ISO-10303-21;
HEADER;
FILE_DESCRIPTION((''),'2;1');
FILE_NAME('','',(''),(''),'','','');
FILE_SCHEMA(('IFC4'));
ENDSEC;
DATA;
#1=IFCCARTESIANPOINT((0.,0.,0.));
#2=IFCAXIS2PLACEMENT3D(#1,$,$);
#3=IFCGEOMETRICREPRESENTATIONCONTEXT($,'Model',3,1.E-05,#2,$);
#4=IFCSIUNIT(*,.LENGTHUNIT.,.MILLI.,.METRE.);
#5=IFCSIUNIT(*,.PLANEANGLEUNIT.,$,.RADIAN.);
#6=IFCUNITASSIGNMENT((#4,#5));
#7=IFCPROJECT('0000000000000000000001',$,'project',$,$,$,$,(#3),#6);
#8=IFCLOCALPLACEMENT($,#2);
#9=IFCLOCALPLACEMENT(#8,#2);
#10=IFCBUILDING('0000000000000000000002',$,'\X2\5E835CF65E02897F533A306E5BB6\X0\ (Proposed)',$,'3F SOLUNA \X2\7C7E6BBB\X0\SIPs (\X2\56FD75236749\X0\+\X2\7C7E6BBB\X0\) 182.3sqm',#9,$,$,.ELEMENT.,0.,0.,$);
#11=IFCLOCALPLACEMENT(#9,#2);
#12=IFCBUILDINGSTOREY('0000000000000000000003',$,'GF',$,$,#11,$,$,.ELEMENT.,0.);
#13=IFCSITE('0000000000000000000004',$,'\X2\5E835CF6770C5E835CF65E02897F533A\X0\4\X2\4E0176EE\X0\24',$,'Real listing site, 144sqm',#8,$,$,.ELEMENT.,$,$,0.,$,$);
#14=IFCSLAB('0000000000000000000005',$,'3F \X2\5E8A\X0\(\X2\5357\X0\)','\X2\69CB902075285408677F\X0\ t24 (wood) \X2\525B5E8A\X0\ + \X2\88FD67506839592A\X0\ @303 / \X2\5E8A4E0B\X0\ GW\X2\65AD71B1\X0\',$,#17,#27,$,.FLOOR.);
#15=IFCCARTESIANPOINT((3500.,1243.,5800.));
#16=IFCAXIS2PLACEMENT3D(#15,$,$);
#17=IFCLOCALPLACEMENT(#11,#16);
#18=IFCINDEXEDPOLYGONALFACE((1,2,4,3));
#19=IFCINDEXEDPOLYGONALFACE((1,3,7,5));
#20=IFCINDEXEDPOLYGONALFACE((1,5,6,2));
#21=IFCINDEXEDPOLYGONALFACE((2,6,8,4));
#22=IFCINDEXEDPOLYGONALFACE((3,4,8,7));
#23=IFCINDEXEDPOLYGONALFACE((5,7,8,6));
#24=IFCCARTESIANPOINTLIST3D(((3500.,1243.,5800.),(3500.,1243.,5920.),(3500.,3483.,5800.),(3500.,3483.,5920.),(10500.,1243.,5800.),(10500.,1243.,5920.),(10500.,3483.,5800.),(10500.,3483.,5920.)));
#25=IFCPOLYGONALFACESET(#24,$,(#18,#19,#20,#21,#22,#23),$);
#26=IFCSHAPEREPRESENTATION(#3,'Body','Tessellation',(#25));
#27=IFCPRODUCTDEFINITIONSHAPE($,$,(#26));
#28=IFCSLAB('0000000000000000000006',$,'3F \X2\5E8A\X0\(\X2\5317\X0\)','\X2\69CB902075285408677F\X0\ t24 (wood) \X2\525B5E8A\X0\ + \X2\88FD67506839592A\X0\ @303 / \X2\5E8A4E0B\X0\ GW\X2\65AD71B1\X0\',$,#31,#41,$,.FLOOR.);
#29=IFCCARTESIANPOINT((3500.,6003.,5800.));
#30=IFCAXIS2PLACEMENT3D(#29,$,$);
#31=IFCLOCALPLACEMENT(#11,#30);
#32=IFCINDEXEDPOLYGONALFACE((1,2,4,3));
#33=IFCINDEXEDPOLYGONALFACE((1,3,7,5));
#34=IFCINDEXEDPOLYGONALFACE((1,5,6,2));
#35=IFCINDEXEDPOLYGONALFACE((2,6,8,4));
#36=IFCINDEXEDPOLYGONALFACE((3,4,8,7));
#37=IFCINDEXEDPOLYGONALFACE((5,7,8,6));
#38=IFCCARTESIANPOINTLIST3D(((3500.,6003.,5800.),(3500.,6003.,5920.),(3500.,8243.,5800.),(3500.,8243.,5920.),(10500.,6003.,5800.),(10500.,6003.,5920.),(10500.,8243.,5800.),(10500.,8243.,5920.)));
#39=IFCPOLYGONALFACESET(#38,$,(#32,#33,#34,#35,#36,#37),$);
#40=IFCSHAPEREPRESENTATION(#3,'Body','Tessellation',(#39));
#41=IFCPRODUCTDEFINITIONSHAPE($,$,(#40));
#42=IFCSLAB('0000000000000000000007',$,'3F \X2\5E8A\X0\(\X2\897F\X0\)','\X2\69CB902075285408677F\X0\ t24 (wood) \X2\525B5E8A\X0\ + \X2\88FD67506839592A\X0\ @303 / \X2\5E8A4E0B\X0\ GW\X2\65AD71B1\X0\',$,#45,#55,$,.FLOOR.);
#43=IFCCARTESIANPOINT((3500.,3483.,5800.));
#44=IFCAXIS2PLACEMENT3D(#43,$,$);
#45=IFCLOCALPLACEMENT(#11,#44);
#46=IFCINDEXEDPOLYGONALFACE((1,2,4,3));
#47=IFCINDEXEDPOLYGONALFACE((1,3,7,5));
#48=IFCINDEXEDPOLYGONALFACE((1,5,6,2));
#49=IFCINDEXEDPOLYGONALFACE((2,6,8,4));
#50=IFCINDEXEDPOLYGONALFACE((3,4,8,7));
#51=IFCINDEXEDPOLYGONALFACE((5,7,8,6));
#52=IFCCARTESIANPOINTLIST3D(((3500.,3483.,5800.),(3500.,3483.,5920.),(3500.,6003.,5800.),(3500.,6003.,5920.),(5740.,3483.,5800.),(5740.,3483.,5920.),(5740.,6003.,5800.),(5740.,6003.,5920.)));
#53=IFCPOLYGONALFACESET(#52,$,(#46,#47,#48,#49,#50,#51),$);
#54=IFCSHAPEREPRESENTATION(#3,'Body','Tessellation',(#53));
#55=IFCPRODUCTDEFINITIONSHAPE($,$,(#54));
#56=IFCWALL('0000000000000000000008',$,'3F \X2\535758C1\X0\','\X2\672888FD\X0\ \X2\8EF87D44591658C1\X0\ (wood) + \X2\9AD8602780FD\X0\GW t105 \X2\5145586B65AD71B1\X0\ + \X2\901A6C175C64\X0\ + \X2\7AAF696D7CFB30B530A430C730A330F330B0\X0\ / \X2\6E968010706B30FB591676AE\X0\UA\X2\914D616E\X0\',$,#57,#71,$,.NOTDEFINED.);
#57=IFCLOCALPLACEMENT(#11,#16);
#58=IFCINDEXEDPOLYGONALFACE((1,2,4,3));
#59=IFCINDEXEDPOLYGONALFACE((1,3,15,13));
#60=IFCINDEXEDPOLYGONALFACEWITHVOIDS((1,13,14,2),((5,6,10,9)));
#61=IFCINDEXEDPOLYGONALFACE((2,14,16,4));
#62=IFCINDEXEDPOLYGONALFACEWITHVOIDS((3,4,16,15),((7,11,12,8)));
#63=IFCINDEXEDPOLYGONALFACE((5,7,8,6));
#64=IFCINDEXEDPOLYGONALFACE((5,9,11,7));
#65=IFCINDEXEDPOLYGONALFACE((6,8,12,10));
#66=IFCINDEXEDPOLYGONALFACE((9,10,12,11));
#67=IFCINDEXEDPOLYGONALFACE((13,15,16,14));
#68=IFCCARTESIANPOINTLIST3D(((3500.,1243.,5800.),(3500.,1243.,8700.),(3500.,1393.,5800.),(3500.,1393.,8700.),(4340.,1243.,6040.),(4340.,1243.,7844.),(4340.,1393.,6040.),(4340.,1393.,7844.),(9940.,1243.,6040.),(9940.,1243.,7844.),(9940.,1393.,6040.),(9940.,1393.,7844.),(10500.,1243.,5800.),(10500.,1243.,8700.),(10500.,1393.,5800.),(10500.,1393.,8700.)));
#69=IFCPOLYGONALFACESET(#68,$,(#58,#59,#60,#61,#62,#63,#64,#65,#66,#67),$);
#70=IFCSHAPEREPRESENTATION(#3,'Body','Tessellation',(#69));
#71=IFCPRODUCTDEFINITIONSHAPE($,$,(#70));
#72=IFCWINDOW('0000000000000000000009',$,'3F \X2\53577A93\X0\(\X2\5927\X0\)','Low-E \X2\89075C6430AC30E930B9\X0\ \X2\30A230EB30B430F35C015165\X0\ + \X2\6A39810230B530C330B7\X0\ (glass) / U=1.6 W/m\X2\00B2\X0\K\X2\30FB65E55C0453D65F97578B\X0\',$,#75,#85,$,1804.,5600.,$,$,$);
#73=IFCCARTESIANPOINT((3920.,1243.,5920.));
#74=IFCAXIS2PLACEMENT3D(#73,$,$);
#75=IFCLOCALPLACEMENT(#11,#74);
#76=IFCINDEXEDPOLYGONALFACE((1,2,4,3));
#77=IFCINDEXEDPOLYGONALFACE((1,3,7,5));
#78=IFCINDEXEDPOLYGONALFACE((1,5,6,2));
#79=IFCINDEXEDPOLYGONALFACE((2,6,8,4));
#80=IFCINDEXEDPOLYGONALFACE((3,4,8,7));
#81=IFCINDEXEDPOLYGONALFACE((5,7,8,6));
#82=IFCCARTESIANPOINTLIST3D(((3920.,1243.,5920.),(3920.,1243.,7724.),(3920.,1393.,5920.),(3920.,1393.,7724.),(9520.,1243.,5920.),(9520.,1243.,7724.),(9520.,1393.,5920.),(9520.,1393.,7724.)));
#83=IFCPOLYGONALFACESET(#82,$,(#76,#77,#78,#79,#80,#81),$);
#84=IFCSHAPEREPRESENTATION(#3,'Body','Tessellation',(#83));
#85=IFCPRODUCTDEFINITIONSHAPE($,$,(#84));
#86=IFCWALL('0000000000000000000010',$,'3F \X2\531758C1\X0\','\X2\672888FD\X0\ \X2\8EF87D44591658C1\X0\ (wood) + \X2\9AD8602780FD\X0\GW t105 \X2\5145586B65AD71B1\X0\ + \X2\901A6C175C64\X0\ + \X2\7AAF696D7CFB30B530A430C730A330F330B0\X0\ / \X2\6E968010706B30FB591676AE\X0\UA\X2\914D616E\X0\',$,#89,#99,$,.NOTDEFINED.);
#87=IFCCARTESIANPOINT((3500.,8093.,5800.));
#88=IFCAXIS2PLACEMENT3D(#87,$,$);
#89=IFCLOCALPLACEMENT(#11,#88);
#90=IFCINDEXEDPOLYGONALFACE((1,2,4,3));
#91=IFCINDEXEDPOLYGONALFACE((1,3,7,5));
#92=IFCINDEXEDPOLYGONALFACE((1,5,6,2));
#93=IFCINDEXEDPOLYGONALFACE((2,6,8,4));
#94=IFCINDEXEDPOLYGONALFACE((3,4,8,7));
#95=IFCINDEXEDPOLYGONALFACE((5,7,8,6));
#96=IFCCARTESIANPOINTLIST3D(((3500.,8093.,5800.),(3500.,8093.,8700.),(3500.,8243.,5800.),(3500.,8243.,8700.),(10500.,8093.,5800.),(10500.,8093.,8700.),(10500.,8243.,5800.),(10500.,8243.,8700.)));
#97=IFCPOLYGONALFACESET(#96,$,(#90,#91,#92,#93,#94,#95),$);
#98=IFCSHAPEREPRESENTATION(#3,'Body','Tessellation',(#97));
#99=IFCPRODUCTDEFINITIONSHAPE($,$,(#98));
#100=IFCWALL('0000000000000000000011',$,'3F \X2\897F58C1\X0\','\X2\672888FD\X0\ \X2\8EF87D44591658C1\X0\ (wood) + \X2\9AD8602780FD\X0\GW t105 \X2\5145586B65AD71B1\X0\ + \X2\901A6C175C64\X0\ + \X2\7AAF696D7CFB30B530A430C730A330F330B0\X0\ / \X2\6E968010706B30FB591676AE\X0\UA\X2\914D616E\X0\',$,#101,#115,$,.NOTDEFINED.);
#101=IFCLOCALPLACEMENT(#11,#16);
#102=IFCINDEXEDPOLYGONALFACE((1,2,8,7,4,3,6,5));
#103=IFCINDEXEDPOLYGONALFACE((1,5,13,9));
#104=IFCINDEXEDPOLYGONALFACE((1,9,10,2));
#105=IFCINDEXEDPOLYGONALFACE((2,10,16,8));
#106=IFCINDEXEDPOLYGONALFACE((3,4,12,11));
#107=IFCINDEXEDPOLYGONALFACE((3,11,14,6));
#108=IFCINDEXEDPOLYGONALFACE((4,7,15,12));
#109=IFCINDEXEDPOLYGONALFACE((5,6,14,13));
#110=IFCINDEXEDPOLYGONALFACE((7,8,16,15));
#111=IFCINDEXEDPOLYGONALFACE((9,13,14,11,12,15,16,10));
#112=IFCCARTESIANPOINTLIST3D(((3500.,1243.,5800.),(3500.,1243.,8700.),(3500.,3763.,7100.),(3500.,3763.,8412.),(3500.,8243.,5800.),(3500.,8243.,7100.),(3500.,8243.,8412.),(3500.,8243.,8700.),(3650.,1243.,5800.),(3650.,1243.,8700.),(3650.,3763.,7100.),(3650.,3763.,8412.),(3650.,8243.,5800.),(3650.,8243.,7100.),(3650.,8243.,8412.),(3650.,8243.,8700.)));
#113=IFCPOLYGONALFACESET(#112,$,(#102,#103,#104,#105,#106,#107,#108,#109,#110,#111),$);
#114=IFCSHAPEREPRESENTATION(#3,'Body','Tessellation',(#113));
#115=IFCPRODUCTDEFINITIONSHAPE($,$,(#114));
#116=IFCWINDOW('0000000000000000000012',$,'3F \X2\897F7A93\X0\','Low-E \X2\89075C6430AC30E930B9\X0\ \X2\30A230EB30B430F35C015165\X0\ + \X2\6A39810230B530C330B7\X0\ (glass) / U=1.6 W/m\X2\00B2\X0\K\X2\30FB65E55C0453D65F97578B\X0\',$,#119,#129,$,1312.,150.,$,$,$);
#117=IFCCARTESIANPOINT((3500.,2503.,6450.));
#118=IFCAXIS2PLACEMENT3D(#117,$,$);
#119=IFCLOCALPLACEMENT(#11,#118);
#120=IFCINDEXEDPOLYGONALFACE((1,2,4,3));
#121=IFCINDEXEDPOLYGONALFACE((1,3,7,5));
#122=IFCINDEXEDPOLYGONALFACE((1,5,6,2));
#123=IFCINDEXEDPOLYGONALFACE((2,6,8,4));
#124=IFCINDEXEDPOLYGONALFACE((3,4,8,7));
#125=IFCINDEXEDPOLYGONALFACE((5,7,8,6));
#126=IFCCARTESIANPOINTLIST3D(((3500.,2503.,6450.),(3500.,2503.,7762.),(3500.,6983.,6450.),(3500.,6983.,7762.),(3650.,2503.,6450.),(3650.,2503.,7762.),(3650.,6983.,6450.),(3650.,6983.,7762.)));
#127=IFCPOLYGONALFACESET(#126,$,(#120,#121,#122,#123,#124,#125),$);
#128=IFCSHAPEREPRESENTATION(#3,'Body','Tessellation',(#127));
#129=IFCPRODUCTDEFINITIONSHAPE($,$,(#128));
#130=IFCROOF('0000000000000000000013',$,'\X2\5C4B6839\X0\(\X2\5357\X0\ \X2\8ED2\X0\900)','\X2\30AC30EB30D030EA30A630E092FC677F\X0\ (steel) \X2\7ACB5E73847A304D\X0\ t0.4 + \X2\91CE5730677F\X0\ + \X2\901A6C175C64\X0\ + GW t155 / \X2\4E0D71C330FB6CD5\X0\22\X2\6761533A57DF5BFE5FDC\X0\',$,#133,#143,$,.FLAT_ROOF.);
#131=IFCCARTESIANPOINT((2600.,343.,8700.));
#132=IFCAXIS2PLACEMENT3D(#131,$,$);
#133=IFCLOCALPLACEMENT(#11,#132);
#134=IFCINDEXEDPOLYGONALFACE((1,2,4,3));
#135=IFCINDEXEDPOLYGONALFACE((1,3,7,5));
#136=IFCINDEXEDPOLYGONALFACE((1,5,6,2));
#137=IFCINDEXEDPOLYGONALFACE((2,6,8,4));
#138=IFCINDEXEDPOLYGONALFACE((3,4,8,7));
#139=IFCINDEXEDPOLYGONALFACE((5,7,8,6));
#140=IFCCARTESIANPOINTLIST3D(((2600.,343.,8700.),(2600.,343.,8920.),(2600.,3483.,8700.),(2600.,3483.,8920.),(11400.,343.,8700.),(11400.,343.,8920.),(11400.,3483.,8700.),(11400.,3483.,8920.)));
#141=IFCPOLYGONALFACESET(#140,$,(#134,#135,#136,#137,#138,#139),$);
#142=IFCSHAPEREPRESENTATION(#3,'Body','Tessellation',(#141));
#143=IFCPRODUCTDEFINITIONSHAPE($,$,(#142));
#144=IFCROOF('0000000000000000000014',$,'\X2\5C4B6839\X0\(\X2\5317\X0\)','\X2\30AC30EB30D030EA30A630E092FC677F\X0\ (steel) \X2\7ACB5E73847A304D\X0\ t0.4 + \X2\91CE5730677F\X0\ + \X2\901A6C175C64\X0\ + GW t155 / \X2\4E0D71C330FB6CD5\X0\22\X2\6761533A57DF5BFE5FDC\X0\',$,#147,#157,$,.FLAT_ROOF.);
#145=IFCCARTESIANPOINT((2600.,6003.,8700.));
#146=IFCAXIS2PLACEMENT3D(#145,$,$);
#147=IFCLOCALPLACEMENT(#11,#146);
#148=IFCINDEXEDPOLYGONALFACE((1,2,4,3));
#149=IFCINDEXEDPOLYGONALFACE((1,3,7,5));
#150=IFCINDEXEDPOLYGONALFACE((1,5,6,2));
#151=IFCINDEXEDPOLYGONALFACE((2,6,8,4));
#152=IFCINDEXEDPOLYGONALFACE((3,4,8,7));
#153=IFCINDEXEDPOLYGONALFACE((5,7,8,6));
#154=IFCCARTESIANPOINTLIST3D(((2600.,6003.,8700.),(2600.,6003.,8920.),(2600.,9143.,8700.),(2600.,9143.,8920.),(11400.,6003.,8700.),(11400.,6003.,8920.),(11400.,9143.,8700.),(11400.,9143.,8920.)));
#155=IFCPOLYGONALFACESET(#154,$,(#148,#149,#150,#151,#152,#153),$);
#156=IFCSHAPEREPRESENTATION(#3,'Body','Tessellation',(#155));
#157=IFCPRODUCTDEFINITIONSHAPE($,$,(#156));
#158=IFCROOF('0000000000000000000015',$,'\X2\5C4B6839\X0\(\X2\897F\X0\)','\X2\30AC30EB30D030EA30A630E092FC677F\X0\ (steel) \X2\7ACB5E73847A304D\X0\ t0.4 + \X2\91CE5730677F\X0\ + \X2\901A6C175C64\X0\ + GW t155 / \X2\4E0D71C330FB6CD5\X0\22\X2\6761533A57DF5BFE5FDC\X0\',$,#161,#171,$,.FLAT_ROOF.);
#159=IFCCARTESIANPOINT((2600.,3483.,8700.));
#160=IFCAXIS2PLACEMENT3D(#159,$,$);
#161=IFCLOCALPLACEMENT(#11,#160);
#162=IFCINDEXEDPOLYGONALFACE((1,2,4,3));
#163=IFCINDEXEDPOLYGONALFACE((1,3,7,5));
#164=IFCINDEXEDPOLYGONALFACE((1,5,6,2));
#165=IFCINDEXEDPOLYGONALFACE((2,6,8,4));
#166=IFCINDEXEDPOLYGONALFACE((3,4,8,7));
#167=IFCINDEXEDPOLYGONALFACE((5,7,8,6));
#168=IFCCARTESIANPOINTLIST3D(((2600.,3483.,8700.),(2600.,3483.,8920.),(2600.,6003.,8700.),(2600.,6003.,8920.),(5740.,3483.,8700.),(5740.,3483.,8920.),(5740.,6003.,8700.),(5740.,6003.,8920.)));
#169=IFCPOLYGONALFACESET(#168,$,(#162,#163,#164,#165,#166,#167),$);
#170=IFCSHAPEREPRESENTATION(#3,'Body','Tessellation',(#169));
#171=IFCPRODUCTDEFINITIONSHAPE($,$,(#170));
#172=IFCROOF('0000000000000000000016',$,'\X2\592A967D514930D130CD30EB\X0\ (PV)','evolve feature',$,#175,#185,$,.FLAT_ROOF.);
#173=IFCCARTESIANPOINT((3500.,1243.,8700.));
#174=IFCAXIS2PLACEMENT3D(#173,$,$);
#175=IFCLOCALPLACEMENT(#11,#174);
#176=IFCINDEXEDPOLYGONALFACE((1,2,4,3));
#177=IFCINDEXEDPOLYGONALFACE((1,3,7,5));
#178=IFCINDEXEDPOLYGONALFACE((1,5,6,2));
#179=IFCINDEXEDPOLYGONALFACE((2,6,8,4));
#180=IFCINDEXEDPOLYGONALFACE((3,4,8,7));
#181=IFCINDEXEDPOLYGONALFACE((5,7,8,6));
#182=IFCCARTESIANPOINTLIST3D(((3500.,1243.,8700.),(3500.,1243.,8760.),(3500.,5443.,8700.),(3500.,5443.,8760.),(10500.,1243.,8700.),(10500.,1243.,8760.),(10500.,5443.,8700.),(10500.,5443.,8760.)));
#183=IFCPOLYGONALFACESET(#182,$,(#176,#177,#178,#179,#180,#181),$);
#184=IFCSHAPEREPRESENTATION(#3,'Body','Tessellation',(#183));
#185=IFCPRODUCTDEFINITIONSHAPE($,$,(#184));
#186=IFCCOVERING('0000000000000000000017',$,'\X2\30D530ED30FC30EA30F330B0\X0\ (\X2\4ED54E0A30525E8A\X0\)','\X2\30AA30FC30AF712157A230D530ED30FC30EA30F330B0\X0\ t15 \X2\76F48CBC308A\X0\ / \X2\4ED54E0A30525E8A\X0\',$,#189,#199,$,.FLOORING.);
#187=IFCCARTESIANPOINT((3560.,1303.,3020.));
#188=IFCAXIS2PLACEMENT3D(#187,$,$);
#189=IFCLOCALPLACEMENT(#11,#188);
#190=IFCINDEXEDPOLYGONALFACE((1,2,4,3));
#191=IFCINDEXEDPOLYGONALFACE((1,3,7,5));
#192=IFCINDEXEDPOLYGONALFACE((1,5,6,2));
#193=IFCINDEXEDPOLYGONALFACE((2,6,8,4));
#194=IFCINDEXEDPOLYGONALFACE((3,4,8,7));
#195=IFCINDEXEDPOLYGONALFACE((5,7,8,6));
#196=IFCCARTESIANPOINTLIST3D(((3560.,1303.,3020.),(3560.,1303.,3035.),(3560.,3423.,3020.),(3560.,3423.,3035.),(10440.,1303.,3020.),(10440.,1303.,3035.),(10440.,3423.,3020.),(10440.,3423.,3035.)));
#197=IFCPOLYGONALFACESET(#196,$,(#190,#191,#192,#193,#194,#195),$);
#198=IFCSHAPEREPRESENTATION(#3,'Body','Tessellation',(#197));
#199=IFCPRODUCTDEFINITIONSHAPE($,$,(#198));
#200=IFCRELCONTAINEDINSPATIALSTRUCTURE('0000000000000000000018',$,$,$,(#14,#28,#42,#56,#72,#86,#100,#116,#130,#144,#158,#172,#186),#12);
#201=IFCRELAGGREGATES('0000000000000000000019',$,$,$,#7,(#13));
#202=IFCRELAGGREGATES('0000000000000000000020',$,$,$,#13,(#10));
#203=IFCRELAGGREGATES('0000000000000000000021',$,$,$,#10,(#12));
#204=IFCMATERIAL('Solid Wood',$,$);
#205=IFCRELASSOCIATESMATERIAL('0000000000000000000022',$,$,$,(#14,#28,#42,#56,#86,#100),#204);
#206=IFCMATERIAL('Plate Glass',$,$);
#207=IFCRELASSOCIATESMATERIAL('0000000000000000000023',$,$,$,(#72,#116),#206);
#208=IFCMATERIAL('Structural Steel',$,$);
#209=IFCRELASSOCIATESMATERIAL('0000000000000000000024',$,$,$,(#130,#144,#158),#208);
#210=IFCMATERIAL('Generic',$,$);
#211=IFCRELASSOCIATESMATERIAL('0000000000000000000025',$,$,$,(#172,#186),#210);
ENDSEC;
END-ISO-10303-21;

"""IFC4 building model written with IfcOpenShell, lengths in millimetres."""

from ifc_helpers import new_model, si_unit, frame, frame_2d, origin, place, context, project, spatial, rectangle, extrude, material, element, fill, save


model = new_model("IFC4")

# Units and contexts
model_context = context("Model", 3, precision=1e-05, world=origin())
ifc_project = project(units=[si_unit("LENGTHUNIT", "METRE", prefix="MILLI"), si_unit("PLANEANGLEUNIT", "RADIAN")], contexts=[model_context])

# Site, building, storey
site_placement = place(None, origin())
site = spatial("IfcSite", under=ifc_project, at=site_placement, Name="広島県広島市西区4丁目24", ObjectType="Real listing site, 144sqm", CompositionType="ELEMENT", RefElevation=0.0)
building_placement = place(site_placement, origin())
building = spatial("IfcBuilding", under=site, at=building_placement, Name="広島市西区の家 (Proposed)", ObjectType="3F SOLUNA 籾殻SIPs (国産杉+籾殻) 182.3sqm", CompositionType="ELEMENT", ElevationOfRefHeight=0.0, ElevationOfTerrain=0.0)
storey_placement = place(building_placement, origin())
storey = spatial("IfcBuildingStorey", under=building, at=storey_placement, Name="GF", CompositionType="ELEMENT", Elevation=0.0)

# Slabs
ifc_material_1 = material(Name="Solid Wood")
slab_1_placement = place(storey_placement, frame((3500.0, 1243.0, 5800.0)))
element("IfcSlab", 1, at=slab_1_placement, inside=storey, material=ifc_material_1, Name="3F 床(南)", Description="構造用合板 t24 (wood) 剛床 + 製材根太 @303 / 床下 GW断熱", PredefinedType="FLOOR", context=model_context, shape_type="SweptSolid", body=[
    extrude(rectangle(XDim=7000.0, YDim=2240.0, at=frame_2d((3500.0, 1120.0))), frame((3500.0, 1243.0, 5800.0)), (0.0, 0.0, 1.0), 120.0),
])
slab_2_placement = place(storey_placement, frame((3500.0, 6003.0, 5800.0)))
element("IfcSlab", 2, at=slab_2_placement, inside=storey, material=ifc_material_1, Name="3F 床(北)", Description="構造用合板 t24 (wood) 剛床 + 製材根太 @303 / 床下 GW断熱", PredefinedType="FLOOR", context=model_context, shape_type="SweptSolid", body=[
    extrude(rectangle(XDim=7000.0, YDim=2240.0, at=frame_2d((3500.0, 1120.0))), frame((3500.0, 6003.0, 5800.0)), (0.0, 0.0, 1.0), 120.0),
])
slab_3_placement = place(storey_placement, frame((3500.0, 3483.0, 5800.0)))
element("IfcSlab", 3, at=slab_3_placement, inside=storey, material=ifc_material_1, Name="3F 床(西)", Description="構造用合板 t24 (wood) 剛床 + 製材根太 @303 / 床下 GW断熱", PredefinedType="FLOOR", context=model_context, shape_type="SweptSolid", body=[
    extrude(rectangle(XDim=2240.0, YDim=2520.0, at=frame_2d((1120.0, 1260.0))), frame((3500.0, 3483.0, 5800.0)), (0.0, 0.0, 1.0), 120.0),
])

# Wall, opening, window
wall_1_placement = place(storey_placement, frame((3500.0, 1243.0, 5800.0)))
wall_1 = element("IfcWall", 4, at=wall_1_placement, inside=storey, material=ifc_material_1, Name="3F 南壁", Description="木製 軸組外壁 (wood) + 高性能GW t105 充填断熱 + 通気層 + 窯業系サイディング / 準耐火・外皮UA配慮", PredefinedType="NOTDEFINED", context=model_context, shape_type="SweptSolid", body=[
    extrude(rectangle(XDim=7000.0, YDim=150.0, at=frame_2d((3500.0, 75.0))), frame((3500.0, 1243.0, 5800.0)), (0.0, 0.0, 1.0), 2900.0),
])
opening_1_placement = place(storey_placement, frame((3920.0, 1243.0, 5920.0)))
opening_1 = element("IfcOpeningElement", 5, at=opening_1_placement, cuts=wall_1, PredefinedType="NOTDEFINED", context=model_context, shape_type="SweptSolid", body=[
    extrude(rectangle(XDim=5600.0, YDim=150.0, at=frame_2d((2800.0, 75.0))), frame((3920.0, 1243.0, 5920.0)), (0.0, 0.0, 1.0), 1804.0),
])
ifc_material_2 = material(Name="Plate Glass")
window_1_placement = place(storey_placement, frame((3920.0, 1243.0, 5920.0)))
window_1 = element("IfcWindow", 6, at=window_1_placement, inside=storey, material=ifc_material_2, Name="3F 南窓(大)", Description="Low-E 複層ガラス アルゴン封入 + 樹脂サッシ (glass) / U=1.6 W/m²K・日射取得型", OverallHeight=1804.0, OverallWidth=5600.0, context=model_context, shape_type="SweptSolid", body=[
    extrude(rectangle(XDim=5600.0, YDim=150.0, at=frame_2d((2800.0, 75.0))), frame((3920.0, 1243.0, 5920.0)), (0.0, 0.0, 1.0), 1804.0),
])
fill(opening_1, window_1)

# Wall
wall_2_placement = place(storey_placement, frame((3500.0, 8093.0, 5800.0)))
element("IfcWall", 7, at=wall_2_placement, inside=storey, material=ifc_material_1, Name="3F 北壁", Description="木製 軸組外壁 (wood) + 高性能GW t105 充填断熱 + 通気層 + 窯業系サイディング / 準耐火・外皮UA配慮", PredefinedType="NOTDEFINED", context=model_context, shape_type="SweptSolid", body=[
    extrude(rectangle(XDim=7000.0, YDim=150.0, at=frame_2d((3500.0, 75.0))), frame((3500.0, 8093.0, 5800.0)), (0.0, 0.0, 1.0), 2900.0),
])

# Wall, opening, window
wall_3_placement = place(storey_placement, frame((3500.0, 1243.0, 5800.0)))
wall_3 = element("IfcWall", 8, at=wall_3_placement, inside=storey, material=ifc_material_1, Name="3F 西壁", Description="木製 軸組外壁 (wood) + 高性能GW t105 充填断熱 + 通気層 + 窯業系サイディング / 準耐火・外皮UA配慮", PredefinedType="NOTDEFINED", context=model_context, shape_type="SweptSolid", body=[
    extrude(rectangle(XDim=150.0, YDim=7000.0, at=frame_2d((75.0, 3500.0))), frame((3500.0, 1243.0, 5800.0)), (0.0, 0.0, 1.0), 2900.0),
])
opening_2_placement = place(storey_placement, frame((3500.0, 2503.0, 6450.0)))
opening_2 = element("IfcOpeningElement", 9, at=opening_2_placement, cuts=wall_3, PredefinedType="NOTDEFINED", context=model_context, shape_type="SweptSolid", body=[
    extrude(rectangle(XDim=150.0, YDim=4480.0, at=frame_2d((75.0, 2240.0))), frame((3500.0, 2503.0, 6450.0)), (0.0, 0.0, 1.0), 1312.0),
])
window_2_placement = place(storey_placement, frame((3500.0, 2503.0, 6450.0)))
window_2 = element("IfcWindow", 10, at=window_2_placement, inside=storey, material=ifc_material_2, Name="3F 西窓", Description="Low-E 複層ガラス アルゴン封入 + 樹脂サッシ (glass) / U=1.6 W/m²K・日射取得型", OverallHeight=1312.0, OverallWidth=150.0, context=model_context, shape_type="SweptSolid", body=[
    extrude(rectangle(XDim=150.0, YDim=4480.0, at=frame_2d((75.0, 2240.0))), frame((3500.0, 2503.0, 6450.0)), (0.0, 0.0, 1.0), 1312.0),
])
fill(opening_2, window_2)

# Roofs
ifc_material_3 = material(Name="Structural Steel")
roof_1_placement = place(storey_placement, frame((2600.0, 343.0, 8700.0)))
element("IfcRoof", 11, at=roof_1_placement, inside=storey, material=ifc_material_3, Name="屋根(南 軒900)", Description="ガルバリウム鋼板 (steel) 立平葺き t0.4 + 野地板 + 通気層 + GW t155 / 不燃・法22条区域対応", PredefinedType="FLAT_ROOF", context=model_context, shape_type="SweptSolid", body=[
    extrude(rectangle(XDim=8800.0, YDim=3140.0, at=frame_2d((4400.0, 1570.0))), frame((2600.0, 343.0, 8700.0)), (0.0, 0.0, 1.0), 220.0),
])
roof_2_placement = place(storey_placement, frame((2600.0, 6003.0, 8700.0)))
element("IfcRoof", 12, at=roof_2_placement, inside=storey, material=ifc_material_3, Name="屋根(北)", Description="ガルバリウム鋼板 (steel) 立平葺き t0.4 + 野地板 + 通気層 + GW t155 / 不燃・法22条区域対応", PredefinedType="FLAT_ROOF", context=model_context, shape_type="SweptSolid", body=[
    extrude(rectangle(XDim=8800.0, YDim=3140.0, at=frame_2d((4400.0, 1570.0))), frame((2600.0, 6003.0, 8700.0)), (0.0, 0.0, 1.0), 220.0),
])
roof_3_placement = place(storey_placement, frame((2600.0, 3483.0, 8700.0)))
element("IfcRoof", 13, at=roof_3_placement, inside=storey, material=ifc_material_3, Name="屋根(西)", Description="ガルバリウム鋼板 (steel) 立平葺き t0.4 + 野地板 + 通気層 + GW t155 / 不燃・法22条区域対応", PredefinedType="FLAT_ROOF", context=model_context, shape_type="SweptSolid", body=[
    extrude(rectangle(XDim=3140.0, YDim=2520.0, at=frame_2d((1570.0, 1260.0))), frame((2600.0, 3483.0, 8700.0)), (0.0, 0.0, 1.0), 220.0),
])
ifc_material_4 = material(Name="Generic")
roof_4_placement = place(storey_placement, frame((3500.0, 1243.0, 8700.0)))
element("IfcRoof", 14, at=roof_4_placement, inside=storey, material=ifc_material_4, Name="太陽光パネル (PV)", Description="evolve feature", PredefinedType="FLAT_ROOF", context=model_context, shape_type="SweptSolid", body=[
    extrude(rectangle(XDim=7000.0, YDim=4200.0, at=frame_2d((3500.0, 2100.0))), frame((3500.0, 1243.0, 8700.0)), (0.0, 0.0, 1.0), 60.0),
])

# Covering
covering_1_placement = place(storey_placement, frame((3560.0, 1303.0, 3020.0)))
element("IfcCovering", 15, at=covering_1_placement, inside=storey, material=ifc_material_4, Name="フローリング (仕上げ床)", Description="オーク無垢フローリング t15 直貼り / 仕上げ床", PredefinedType="FLOORING", context=model_context, shape_type="SweptSolid", body=[
    extrude(rectangle(XDim=6880.0, YDim=2120.0, at=frame_2d((3440.0, 1060.0))), frame((3560.0, 1303.0, 3020.0)), (0.0, 0.0, 1.0), 15.0),
])

save(model, "model.ifc")
